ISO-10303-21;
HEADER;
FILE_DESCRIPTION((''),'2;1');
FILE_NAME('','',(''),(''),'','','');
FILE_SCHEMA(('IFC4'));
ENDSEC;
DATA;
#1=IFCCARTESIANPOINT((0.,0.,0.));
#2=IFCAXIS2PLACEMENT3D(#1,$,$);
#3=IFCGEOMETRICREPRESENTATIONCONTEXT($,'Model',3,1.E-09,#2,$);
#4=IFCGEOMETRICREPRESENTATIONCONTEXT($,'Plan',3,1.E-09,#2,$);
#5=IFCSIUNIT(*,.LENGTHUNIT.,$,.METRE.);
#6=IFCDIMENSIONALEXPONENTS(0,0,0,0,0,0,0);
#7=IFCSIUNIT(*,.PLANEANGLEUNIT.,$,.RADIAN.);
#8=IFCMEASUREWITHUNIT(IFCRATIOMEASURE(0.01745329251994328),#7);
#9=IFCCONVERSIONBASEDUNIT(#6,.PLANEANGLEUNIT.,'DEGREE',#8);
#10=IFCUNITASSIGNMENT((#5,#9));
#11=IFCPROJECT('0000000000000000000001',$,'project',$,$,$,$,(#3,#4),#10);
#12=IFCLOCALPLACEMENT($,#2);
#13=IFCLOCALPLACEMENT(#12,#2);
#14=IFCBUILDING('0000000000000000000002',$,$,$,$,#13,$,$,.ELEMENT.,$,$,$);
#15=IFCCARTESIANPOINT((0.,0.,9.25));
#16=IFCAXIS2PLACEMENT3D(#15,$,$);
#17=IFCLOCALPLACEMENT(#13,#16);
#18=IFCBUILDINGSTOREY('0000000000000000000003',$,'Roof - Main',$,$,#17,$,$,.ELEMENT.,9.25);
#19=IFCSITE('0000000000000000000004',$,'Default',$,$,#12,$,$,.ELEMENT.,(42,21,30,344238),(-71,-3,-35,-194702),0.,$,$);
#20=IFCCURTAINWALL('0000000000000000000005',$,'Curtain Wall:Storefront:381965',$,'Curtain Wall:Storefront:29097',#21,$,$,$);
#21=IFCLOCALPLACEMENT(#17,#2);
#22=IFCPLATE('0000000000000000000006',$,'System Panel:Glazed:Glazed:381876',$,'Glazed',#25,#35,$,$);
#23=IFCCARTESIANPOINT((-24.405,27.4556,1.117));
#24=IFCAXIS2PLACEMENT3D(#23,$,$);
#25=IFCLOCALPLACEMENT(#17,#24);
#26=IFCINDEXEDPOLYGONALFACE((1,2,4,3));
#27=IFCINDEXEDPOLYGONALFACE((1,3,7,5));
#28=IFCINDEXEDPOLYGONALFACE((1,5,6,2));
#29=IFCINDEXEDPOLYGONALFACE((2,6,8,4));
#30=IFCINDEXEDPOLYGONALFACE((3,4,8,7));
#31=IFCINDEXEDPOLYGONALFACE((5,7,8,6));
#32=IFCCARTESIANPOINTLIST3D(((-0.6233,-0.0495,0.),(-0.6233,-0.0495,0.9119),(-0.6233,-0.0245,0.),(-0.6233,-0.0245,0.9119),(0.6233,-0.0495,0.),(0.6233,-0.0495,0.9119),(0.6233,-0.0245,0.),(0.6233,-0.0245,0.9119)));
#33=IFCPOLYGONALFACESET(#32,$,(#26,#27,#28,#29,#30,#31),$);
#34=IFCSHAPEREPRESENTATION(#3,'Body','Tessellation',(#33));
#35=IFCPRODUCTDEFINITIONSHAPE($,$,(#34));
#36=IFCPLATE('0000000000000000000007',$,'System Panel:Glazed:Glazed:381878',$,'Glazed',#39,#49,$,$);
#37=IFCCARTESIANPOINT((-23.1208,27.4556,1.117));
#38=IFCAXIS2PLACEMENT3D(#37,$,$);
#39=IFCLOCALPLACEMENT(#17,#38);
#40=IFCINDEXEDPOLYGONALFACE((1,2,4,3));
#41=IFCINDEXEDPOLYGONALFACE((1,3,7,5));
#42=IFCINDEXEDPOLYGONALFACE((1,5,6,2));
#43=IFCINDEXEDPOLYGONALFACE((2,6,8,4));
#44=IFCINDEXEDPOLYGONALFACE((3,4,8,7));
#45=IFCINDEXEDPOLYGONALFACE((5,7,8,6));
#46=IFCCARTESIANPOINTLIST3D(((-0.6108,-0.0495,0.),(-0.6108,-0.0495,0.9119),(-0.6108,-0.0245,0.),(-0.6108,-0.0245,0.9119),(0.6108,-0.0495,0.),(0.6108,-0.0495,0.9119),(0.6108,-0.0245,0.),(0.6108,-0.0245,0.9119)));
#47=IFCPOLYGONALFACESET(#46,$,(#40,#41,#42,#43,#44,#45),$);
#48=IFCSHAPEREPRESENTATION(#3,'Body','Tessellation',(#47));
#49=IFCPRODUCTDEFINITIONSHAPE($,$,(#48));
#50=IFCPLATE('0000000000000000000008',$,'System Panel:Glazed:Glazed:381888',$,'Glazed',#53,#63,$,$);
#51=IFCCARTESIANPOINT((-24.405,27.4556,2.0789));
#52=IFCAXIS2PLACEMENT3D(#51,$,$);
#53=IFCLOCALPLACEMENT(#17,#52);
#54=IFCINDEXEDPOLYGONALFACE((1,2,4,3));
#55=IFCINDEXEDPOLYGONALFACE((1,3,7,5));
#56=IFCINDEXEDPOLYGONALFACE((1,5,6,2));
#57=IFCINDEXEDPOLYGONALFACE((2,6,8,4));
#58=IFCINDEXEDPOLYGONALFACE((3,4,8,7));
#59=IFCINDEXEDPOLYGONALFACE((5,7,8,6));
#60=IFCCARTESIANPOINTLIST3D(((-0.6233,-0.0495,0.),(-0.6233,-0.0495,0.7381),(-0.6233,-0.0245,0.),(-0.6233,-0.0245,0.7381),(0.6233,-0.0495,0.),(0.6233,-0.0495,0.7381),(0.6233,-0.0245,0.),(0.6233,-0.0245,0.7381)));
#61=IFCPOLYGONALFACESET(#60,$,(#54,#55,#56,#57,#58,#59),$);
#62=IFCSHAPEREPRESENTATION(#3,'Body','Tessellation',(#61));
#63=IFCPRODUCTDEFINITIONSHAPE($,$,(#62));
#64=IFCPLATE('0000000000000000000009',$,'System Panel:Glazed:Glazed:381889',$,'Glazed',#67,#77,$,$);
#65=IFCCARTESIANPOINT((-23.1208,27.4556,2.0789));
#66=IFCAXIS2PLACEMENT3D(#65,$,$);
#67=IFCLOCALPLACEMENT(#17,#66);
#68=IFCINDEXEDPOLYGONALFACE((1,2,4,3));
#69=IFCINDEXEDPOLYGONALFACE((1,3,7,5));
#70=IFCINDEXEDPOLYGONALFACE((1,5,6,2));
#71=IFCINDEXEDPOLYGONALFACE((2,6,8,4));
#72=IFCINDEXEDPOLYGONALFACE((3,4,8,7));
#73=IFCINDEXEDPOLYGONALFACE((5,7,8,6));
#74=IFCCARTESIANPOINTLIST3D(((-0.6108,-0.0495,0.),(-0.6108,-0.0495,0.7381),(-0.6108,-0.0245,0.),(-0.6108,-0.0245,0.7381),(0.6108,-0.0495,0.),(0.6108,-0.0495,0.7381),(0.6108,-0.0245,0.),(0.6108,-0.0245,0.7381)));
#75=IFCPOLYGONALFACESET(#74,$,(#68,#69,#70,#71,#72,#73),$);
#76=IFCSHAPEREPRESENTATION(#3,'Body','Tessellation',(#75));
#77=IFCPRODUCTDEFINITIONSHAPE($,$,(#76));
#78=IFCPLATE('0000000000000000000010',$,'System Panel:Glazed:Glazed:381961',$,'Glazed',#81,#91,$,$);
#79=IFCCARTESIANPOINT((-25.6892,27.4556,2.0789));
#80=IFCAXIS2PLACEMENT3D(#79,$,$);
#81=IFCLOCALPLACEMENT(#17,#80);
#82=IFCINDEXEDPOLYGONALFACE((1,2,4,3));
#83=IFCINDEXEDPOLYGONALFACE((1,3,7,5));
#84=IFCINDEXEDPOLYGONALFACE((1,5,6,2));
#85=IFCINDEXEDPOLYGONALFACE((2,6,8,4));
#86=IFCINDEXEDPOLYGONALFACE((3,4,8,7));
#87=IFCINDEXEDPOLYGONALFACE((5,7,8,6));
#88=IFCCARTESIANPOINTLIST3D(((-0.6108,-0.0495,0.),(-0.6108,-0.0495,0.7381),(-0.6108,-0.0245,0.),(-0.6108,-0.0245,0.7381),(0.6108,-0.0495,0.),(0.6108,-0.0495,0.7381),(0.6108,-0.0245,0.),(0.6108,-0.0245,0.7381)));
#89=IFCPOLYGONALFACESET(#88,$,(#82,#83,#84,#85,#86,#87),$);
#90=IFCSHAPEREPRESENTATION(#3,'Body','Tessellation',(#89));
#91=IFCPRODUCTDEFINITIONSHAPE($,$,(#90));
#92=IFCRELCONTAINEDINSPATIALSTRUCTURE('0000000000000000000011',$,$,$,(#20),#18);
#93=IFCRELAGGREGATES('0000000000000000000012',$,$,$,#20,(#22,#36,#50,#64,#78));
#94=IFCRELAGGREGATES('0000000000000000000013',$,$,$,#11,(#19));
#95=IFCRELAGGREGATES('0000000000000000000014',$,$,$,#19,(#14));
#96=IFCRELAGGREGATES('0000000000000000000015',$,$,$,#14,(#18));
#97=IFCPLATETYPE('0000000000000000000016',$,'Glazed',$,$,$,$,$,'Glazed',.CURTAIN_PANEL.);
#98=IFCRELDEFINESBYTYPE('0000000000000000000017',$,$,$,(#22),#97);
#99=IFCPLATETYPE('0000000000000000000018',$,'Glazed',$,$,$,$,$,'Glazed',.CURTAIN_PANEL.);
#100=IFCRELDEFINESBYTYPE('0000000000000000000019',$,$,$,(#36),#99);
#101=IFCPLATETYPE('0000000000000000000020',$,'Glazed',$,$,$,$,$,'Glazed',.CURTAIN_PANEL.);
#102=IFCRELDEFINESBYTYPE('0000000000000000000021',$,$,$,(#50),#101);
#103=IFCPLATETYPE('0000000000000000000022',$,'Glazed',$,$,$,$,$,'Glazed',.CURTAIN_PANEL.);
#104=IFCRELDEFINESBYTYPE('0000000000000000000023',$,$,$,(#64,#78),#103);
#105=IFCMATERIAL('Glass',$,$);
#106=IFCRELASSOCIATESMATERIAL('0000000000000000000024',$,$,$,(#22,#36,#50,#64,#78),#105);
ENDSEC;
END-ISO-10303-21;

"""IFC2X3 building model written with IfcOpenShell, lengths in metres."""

from ifc_helpers import new_model, entity, si_unit, converted_unit, frame, origin, origin_2d_with_axis, place, context, project, spatial, rectangle, extrude, source, transform, mapped, material, type_object, type_shapes, element, aggregate, save


model = new_model("IFC2X3")

# Units and contexts
model_context = context("Model", 3, precision=1e-09, world=origin())
plan_context = context("Plan", 3, precision=1e-09, world=origin())
ifc_project = project(units=[si_unit("LENGTHUNIT", "METRE"), converted_unit("PLANEANGLEUNIT", "DEGREE", entity("IfcRatioMeasure", 0.01745329251994328), si_unit("PLANEANGLEUNIT", "RADIAN"), dimensions=[0, 0, 0, 0, 0, 0, 0])], contexts=[model_context, plan_context])

# Site, building, storey
site_placement = place(None, origin())
site = spatial("IfcSite", under=ifc_project, at=site_placement, Name="Default", CompositionType="ELEMENT", RefLatitude=(42, 21, 30, 344238), RefLongitude=(-71, -3, -35, -194702), RefElevation=0.0)
building_placement = place(site_placement, origin())
building = spatial("IfcBuilding", under=site, at=building_placement, CompositionType="ELEMENT")
storey_placement = place(building_placement, frame((0.0, 0.0, 9.25)))
storey = spatial("IfcBuildingStorey", under=building, at=storey_placement, Name="Roof - Main", CompositionType="ELEMENT", Elevation=9.25)

# Curtain wall, plates
curtain_wall_1_placement = place(storey_placement, origin())
curtain_wall_1 = element("IfcCurtainWall", 1, at=curtain_wall_1_placement, inside=storey, Name="Curtain Wall:Storefront:381965", ObjectType="Curtain Wall:Storefront:29097")
ifc_material_1 = material(Name="Glass")
plate_type_1 = type_object("IfcPlateType", Name="Glazed", ElementType="Glazed", PredefinedType="CURTAIN_PANEL")
shared_shape_1 = source(origin(), model_context, "Body", "SweptSolid", [
    extrude(rectangle(XDim=0.025, YDim=1.2467, at=origin_2d_with_axis()), frame((0.0, -0.037, 0.0), z_axis=(0.0, 0.0, 1.0), x_axis=(0.0, 1.0, 0.0)), (0.0, 0.0, 1.0), 0.9119),
])
type_shapes(plate_type_1, [shared_shape_1])
plate_1_placement = place(storey_placement, frame((-24.405, 27.4556, 1.117)))
plate_1 = element("IfcPlate", 2, at=plate_1_placement, type_object=plate_type_1, material=ifc_material_1, Name="System Panel:Glazed:Glazed:381876", ObjectType="Glazed", context=model_context, shape_type="MappedRepresentation", body=[
    mapped(shared_shape_1, transform((0.0, 0.0, 0.0), scale=1.0)),
])
plate_type_2 = type_object("IfcPlateType", Name="Glazed", ElementType="Glazed", PredefinedType="CURTAIN_PANEL")
shared_shape_2 = source(origin(), model_context, "Body", "SweptSolid", [
    extrude(rectangle(XDim=0.025, YDim=1.2217, at=origin_2d_with_axis()), frame((0.0, -0.037, 0.0), z_axis=(0.0, 0.0, 1.0), x_axis=(0.0, 1.0, 0.0)), (0.0, 0.0, 1.0), 0.9119),
])
type_shapes(plate_type_2, [shared_shape_2])
plate_2_placement = place(storey_placement, frame((-23.1208, 27.4556, 1.117)))
plate_2 = element("IfcPlate", 3, at=plate_2_placement, type_object=plate_type_2, material=ifc_material_1, Name="System Panel:Glazed:Glazed:381878", ObjectType="Glazed", context=model_context, shape_type="MappedRepresentation", body=[
    mapped(shared_shape_2, transform((0.0, 0.0, 0.0), scale=1.0)),
])
plate_type_3 = type_object("IfcPlateType", Name="Glazed", ElementType="Glazed", PredefinedType="CURTAIN_PANEL")
shared_shape_3 = source(origin(), model_context, "Body", "SweptSolid", [
    extrude(rectangle(XDim=0.025, YDim=1.2467, at=origin_2d_with_axis()), frame((0.0, -0.037, 0.0), z_axis=(0.0, 0.0, 1.0), x_axis=(0.0, 1.0, 0.0)), (0.0, 0.0, 1.0), 0.7381),
])
type_shapes(plate_type_3, [shared_shape_3])
plate_3_placement = place(storey_placement, frame((-24.405, 27.4556, 2.0789)))
plate_3 = element("IfcPlate", 4, at=plate_3_placement, type_object=plate_type_3, material=ifc_material_1, Name="System Panel:Glazed:Glazed:381888", ObjectType="Glazed", context=model_context, shape_type="MappedRepresentation", body=[
    mapped(shared_shape_3, transform((0.0, 0.0, 0.0), scale=1.0)),
])
plate_type_4 = type_object("IfcPlateType", Name="Glazed", ElementType="Glazed", PredefinedType="CURTAIN_PANEL")
shared_shape_4 = source(origin(), model_context, "Body", "SweptSolid", [
    extrude(rectangle(XDim=0.025, YDim=1.2217, at=origin_2d_with_axis()), frame((0.0, -0.037, 0.0), z_axis=(0.0, 0.0, 1.0), x_axis=(0.0, 1.0, 0.0)), (0.0, 0.0, 1.0), 0.7381),
])
type_shapes(plate_type_4, [shared_shape_4])
plate_4_placement = place(storey_placement, frame((-23.1208, 27.4556, 2.0789)))
plate_4 = element("IfcPlate", 5, at=plate_4_placement, type_object=plate_type_4, material=ifc_material_1, Name="System Panel:Glazed:Glazed:381889", ObjectType="Glazed", context=model_context, shape_type="MappedRepresentation", body=[
    mapped(shared_shape_4, transform((0.0, 0.0, 0.0), scale=1.0)),
])
plate_5_placement = place(storey_placement, frame((-25.6892, 27.4556, 2.0789)))
plate_5 = element("IfcPlate", 6, at=plate_5_placement, type_object=plate_type_4, material=ifc_material_1, Name="System Panel:Glazed:Glazed:381961", ObjectType="Glazed", context=model_context, shape_type="MappedRepresentation", body=[
    mapped(shared_shape_4, transform((0.0, 0.0, 0.0), scale=1.0)),
])
aggregate(curtain_wall_1, [plate_1, plate_2, plate_3, plate_4, plate_5])

save(model, "model.ifc")
